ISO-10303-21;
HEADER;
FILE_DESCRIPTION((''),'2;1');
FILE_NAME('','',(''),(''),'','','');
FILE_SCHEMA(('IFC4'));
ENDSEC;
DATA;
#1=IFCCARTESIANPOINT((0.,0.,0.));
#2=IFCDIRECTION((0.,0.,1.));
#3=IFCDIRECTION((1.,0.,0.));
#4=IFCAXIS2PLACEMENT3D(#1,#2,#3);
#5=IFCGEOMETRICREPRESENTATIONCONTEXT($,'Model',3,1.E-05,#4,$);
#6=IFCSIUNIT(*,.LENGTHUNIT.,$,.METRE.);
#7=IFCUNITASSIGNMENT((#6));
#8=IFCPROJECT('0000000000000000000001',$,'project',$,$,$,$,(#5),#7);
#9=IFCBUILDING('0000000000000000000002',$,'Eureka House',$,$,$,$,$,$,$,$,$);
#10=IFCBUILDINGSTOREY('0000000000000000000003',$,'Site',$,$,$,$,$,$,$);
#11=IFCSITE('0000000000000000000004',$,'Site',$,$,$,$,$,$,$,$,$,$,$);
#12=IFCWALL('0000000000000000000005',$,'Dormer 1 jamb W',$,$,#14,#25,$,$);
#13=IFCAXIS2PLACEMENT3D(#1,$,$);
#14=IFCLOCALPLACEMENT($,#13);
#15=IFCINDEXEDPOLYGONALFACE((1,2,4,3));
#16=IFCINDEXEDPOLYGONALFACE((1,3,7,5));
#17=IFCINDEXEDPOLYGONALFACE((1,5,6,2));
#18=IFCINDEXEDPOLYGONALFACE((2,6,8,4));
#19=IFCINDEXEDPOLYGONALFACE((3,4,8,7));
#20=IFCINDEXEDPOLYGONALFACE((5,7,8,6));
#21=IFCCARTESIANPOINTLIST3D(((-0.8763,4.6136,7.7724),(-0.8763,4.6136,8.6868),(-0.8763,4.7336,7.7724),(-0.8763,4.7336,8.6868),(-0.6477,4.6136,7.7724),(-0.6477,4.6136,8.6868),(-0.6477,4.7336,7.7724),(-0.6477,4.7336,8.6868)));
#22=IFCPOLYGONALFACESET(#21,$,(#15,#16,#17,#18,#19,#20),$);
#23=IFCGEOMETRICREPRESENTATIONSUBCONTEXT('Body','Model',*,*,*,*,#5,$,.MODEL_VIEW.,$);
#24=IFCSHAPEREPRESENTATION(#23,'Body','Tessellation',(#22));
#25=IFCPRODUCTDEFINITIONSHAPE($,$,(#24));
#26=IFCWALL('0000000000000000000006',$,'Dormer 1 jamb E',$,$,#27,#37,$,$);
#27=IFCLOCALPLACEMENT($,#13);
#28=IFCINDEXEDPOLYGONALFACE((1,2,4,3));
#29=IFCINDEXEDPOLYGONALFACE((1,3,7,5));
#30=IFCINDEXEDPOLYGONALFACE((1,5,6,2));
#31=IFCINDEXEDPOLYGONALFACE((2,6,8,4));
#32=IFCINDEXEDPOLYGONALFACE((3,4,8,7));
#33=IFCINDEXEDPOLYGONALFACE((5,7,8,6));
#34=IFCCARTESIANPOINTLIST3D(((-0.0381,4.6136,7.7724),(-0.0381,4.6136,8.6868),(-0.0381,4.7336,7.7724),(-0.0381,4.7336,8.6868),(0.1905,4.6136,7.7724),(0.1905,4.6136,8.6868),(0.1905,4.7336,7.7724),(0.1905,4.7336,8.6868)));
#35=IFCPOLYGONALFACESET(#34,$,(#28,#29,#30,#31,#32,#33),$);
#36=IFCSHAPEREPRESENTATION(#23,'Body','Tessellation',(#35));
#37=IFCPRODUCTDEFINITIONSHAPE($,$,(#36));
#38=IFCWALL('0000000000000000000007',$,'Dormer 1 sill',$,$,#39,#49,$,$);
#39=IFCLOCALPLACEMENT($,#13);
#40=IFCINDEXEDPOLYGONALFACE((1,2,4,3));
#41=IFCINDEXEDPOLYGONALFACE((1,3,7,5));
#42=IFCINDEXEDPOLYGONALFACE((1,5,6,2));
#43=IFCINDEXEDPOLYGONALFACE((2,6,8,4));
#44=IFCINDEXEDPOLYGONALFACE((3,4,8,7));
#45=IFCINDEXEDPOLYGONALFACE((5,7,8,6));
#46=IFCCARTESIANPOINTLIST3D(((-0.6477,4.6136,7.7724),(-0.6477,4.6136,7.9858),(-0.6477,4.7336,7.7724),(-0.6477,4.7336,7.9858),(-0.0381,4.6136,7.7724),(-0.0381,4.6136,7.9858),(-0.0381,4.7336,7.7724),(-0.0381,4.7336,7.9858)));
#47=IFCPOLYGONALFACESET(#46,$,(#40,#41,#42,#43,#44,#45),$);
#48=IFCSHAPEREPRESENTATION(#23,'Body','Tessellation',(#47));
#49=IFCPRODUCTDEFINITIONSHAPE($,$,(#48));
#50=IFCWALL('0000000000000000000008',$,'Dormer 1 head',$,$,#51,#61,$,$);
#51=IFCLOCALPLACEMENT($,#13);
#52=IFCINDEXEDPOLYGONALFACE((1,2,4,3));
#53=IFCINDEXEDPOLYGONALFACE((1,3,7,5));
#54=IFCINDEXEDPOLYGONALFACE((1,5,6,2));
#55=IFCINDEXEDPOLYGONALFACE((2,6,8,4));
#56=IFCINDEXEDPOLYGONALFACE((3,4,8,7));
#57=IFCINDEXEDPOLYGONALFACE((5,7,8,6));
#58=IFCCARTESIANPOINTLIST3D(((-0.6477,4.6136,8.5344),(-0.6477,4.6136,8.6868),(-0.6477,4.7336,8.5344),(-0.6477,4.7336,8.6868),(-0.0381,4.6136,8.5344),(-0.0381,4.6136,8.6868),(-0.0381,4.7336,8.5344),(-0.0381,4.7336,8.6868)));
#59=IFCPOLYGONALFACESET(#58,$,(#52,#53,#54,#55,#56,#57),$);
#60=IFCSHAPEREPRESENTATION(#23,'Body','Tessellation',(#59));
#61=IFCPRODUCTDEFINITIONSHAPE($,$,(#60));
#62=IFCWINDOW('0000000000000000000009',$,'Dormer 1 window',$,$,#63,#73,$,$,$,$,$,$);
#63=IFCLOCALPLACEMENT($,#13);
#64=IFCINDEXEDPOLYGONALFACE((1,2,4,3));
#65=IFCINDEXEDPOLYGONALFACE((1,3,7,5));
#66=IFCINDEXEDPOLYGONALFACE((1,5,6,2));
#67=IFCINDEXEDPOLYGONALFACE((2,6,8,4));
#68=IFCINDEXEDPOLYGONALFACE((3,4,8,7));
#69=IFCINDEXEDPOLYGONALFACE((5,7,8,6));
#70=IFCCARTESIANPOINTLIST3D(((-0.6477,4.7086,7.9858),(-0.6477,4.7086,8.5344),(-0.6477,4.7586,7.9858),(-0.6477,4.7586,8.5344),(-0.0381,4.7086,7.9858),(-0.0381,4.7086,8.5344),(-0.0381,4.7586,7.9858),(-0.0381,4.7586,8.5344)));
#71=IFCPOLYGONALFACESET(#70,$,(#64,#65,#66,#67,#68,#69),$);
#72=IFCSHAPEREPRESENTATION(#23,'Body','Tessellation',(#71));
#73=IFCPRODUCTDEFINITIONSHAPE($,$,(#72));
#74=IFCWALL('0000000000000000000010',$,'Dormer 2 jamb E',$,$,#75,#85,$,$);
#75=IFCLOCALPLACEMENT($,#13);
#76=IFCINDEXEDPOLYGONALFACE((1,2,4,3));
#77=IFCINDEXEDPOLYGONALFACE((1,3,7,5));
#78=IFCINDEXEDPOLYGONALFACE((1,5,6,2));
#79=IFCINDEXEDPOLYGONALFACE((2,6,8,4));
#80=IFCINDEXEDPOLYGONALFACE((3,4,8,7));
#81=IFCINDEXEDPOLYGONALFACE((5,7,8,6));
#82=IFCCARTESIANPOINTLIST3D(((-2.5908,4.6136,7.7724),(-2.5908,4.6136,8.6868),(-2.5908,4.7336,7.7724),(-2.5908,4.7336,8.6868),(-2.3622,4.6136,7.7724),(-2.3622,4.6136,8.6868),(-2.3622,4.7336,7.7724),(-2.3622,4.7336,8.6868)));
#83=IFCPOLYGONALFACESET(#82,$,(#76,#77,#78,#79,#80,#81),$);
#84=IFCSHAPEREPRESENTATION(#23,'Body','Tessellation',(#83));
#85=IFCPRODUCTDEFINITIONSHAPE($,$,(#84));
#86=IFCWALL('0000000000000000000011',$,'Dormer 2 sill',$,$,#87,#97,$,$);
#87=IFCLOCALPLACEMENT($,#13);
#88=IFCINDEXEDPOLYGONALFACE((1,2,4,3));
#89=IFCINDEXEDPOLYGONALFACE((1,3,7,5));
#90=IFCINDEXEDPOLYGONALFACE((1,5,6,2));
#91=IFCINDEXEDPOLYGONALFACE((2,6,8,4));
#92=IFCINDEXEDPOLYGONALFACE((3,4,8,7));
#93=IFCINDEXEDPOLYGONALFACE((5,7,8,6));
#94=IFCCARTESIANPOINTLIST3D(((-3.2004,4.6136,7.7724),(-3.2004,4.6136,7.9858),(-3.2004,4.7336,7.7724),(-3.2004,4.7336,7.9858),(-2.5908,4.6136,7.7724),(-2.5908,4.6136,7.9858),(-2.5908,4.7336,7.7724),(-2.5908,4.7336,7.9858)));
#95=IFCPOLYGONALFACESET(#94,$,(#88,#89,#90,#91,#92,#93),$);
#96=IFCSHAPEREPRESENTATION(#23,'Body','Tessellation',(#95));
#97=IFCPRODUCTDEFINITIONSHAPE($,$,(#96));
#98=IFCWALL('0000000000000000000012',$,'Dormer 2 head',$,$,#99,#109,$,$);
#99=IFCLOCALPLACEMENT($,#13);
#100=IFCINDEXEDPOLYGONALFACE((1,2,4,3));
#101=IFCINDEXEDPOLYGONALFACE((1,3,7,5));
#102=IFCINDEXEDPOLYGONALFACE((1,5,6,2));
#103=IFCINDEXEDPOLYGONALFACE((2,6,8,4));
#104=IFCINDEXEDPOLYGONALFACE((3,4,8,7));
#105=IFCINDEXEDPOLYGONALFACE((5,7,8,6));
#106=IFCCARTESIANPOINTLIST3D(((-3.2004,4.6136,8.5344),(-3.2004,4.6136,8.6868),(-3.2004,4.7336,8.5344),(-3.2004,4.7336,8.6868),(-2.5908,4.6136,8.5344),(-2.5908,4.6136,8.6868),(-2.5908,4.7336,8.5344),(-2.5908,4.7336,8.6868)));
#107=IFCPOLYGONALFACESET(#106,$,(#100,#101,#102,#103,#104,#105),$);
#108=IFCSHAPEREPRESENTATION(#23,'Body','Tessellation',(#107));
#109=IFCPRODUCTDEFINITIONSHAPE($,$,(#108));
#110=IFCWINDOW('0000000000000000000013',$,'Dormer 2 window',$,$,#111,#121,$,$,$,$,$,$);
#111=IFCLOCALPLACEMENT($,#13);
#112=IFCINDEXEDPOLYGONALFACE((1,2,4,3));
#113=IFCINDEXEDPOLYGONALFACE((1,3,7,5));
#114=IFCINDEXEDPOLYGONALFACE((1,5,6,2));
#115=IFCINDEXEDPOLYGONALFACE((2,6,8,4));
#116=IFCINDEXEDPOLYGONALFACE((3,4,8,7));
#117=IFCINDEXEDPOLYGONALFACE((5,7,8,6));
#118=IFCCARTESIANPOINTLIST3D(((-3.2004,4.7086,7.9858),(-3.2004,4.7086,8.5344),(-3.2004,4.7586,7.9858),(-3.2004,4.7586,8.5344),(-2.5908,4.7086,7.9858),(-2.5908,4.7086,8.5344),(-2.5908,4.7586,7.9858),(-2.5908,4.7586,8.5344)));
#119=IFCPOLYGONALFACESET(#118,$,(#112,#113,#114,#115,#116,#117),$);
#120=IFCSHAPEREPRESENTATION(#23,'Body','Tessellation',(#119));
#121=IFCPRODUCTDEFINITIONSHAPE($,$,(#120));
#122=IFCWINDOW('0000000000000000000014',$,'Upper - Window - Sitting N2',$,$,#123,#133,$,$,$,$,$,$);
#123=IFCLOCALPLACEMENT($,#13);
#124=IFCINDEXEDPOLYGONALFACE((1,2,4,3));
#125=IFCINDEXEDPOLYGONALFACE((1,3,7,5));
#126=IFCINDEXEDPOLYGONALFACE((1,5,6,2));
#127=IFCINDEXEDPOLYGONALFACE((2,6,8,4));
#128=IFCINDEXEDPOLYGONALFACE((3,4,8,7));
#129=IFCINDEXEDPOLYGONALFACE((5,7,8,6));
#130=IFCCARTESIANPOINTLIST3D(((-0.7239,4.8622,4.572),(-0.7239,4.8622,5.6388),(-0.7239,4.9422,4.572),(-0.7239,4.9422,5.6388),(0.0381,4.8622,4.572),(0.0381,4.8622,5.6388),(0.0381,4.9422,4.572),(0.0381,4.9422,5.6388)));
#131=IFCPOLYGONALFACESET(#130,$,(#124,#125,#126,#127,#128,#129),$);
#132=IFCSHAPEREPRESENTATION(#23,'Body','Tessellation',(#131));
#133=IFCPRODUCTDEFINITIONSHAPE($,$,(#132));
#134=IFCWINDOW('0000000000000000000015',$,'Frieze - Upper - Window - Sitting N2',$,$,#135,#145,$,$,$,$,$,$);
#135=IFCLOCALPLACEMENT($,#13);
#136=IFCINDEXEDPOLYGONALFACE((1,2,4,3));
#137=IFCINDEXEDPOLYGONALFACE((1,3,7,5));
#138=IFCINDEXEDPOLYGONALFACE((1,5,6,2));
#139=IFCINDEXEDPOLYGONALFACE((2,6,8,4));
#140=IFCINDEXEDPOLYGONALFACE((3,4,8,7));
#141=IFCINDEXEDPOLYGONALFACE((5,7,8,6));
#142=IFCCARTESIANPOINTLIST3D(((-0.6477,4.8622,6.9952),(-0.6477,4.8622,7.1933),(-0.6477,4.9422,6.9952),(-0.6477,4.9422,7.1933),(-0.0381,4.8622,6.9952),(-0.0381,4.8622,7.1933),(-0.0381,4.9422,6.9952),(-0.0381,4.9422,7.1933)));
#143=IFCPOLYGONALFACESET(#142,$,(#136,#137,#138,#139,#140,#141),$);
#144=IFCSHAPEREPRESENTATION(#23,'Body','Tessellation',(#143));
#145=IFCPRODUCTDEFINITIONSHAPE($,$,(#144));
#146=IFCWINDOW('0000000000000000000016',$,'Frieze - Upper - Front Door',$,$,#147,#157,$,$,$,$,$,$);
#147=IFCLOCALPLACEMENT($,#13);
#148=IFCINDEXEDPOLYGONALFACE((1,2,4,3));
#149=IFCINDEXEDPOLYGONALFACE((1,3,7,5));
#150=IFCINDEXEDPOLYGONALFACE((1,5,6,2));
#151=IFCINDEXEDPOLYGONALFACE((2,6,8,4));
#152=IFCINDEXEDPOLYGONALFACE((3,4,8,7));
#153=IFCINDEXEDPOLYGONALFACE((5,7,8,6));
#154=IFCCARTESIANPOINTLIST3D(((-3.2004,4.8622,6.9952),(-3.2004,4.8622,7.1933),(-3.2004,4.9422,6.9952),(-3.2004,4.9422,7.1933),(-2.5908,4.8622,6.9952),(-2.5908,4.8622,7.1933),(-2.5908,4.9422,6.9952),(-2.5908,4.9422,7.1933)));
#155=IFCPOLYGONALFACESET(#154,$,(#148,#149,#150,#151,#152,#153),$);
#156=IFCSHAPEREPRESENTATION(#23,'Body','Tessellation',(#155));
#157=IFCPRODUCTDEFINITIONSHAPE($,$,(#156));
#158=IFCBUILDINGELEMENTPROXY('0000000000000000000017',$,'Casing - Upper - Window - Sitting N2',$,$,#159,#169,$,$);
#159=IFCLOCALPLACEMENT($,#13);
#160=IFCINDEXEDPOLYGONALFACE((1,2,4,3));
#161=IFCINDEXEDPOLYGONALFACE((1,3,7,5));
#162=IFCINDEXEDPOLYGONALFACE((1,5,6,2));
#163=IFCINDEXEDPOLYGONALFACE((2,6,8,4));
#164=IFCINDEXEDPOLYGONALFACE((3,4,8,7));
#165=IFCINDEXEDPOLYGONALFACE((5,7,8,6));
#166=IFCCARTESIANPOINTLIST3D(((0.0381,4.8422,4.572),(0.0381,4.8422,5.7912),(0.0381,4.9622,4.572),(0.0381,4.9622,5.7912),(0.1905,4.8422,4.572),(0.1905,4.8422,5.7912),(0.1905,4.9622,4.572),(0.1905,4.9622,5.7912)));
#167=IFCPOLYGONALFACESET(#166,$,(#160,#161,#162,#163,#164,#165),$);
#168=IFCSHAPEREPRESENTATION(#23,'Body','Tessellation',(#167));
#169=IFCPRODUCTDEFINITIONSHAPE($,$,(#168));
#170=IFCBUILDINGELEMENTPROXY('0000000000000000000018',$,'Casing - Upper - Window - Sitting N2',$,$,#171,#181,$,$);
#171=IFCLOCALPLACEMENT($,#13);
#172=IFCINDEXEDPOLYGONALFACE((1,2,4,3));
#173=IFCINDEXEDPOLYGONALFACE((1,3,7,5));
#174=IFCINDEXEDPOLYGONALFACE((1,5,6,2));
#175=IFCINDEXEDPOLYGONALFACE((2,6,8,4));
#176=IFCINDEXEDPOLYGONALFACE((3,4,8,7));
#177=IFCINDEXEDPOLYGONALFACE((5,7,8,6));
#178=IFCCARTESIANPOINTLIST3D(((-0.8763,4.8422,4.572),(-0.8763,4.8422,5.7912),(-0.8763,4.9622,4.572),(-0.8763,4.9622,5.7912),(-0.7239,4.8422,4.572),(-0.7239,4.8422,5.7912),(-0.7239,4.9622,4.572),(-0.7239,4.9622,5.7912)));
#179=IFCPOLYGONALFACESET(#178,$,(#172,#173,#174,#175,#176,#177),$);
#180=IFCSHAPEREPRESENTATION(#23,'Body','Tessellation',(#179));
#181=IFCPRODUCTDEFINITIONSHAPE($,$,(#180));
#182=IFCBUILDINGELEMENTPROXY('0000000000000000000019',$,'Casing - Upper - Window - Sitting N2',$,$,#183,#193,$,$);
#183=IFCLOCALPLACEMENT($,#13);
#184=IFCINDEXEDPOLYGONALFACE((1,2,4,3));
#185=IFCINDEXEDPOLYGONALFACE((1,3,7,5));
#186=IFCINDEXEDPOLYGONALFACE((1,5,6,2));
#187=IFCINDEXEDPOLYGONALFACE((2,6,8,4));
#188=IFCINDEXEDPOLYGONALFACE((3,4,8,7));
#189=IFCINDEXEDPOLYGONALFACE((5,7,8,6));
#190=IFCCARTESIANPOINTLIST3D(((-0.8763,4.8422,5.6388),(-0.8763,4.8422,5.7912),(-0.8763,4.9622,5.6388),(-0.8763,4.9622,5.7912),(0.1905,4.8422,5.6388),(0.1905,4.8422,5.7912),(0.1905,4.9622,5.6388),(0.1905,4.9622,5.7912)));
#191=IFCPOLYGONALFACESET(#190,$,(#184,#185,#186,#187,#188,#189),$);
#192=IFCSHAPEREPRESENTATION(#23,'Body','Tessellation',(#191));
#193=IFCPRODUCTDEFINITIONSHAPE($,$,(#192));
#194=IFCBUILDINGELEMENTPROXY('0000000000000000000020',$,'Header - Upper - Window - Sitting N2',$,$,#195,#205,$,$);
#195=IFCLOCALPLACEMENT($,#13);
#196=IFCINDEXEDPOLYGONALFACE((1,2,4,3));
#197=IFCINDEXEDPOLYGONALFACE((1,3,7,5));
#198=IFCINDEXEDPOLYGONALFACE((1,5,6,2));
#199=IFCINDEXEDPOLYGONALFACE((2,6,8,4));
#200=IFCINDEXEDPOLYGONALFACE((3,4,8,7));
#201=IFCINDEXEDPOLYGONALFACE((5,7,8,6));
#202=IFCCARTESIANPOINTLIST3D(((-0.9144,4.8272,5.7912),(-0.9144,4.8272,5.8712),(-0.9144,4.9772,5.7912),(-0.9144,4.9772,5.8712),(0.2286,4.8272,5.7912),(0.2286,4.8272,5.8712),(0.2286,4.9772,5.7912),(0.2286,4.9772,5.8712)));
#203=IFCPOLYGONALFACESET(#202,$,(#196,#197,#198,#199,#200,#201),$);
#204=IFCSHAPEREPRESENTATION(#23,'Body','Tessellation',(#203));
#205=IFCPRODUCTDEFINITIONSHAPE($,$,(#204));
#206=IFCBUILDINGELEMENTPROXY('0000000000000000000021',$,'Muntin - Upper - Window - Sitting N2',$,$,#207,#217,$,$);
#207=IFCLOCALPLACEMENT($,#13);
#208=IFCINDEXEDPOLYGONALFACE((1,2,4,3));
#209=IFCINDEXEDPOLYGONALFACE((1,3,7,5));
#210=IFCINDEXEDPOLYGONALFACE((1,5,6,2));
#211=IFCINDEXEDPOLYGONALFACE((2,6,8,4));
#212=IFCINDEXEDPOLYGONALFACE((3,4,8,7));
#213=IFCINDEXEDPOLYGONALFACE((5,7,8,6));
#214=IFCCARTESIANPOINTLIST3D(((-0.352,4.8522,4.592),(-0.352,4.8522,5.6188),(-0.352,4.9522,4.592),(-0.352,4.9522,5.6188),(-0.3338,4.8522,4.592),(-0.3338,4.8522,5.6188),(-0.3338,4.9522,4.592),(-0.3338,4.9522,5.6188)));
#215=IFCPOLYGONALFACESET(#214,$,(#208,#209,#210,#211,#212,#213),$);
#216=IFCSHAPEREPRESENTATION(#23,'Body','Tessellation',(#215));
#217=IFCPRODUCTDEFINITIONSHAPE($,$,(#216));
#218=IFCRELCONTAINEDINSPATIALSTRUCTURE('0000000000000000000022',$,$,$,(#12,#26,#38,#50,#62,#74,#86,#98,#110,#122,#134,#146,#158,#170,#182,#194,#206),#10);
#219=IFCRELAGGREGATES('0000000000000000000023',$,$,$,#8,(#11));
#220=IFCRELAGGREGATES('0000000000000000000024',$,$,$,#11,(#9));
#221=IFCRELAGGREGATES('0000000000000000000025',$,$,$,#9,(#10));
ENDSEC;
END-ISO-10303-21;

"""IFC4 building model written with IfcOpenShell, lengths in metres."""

from ifc_helpers import new_model, si_unit, frame, origin, origin_with_axes, origin_2d, place, context, subcontext, project, spatial, rectangle, extrude, element, save


model = new_model("IFC4")

# Units and contexts
model_context = context("Model", 3, precision=1e-05, world=origin_with_axes())
body_context = subcontext(model_context, "Body", "Model", "MODEL_VIEW")
ifc_project = project(units=[si_unit("LENGTHUNIT", "METRE")], contexts=[model_context])

# Site, building, storey
site = spatial("IfcSite", under=ifc_project, Name="Site")
building = spatial("IfcBuilding", under=site, Name="Eureka House")
storey = spatial("IfcBuildingStorey", under=building, Name="Site")

# Walls
wall_1_placement = place(None, frame((-0.762, 4.6736, 7.7724), z_axis=(0.0, 0.0, 1.0), x_axis=(1.0, 0.0, 0.0)))
element("IfcWall", 1, at=wall_1_placement, inside=storey, Name="Dormer 1 jamb W", context=body_context, shape_type="SweptSolid", body=[
    extrude(rectangle(XDim=0.2286, YDim=0.12, at=origin_2d()), origin(), (0.0, 0.0, 1.0), 0.9144),
])
wall_2_placement = place(None, frame((0.0762, 4.6736, 7.7724), z_axis=(0.0, 0.0, 1.0), x_axis=(1.0, 0.0, 0.0)))
element("IfcWall", 2, at=wall_2_placement, inside=storey, Name="Dormer 1 jamb E", context=body_context, shape_type="SweptSolid", body=[
    extrude(rectangle(XDim=0.2286, YDim=0.12, at=origin_2d()), origin(), (0.0, 0.0, 1.0), 0.9144),
])
wall_3_placement = place(None, frame((-0.3429, 4.6736, 7.7724), z_axis=(0.0, 0.0, 1.0), x_axis=(1.0, 0.0, 0.0)))
element("IfcWall", 3, at=wall_3_placement, inside=storey, Name="Dormer 1 sill", context=body_context, shape_type="SweptSolid", body=[
    extrude(rectangle(XDim=0.6096, YDim=0.12, at=origin_2d()), origin(), (0.0, 0.0, 1.0), 0.2134),
])
wall_4_placement = place(None, frame((-0.3429, 4.6736, 8.5344), z_axis=(0.0, 0.0, 1.0), x_axis=(1.0, 0.0, 0.0)))
element("IfcWall", 4, at=wall_4_placement, inside=storey, Name="Dormer 1 head", context=body_context, shape_type="SweptSolid", body=[
    extrude(rectangle(XDim=0.6096, YDim=0.12, at=origin_2d()), origin(), (0.0, 0.0, 1.0), 0.1524),
])

# Window
window_1_placement = place(None, frame((-0.3429, 4.7336, 7.9858), z_axis=(0.0, 0.0, 1.0), x_axis=(1.0, 0.0, 0.0)))
element("IfcWindow", 5, at=window_1_placement, inside=storey, Name="Dormer 1 window", context=body_context, shape_type="SweptSolid", body=[
    extrude(rectangle(XDim=0.6096, YDim=0.05, at=origin_2d()), origin(), (0.0, 0.0, 1.0), 0.5486),
])

# Walls
wall_5_placement = place(None, frame((-2.4765, 4.6736, 7.7724), z_axis=(0.0, 0.0, 1.0), x_axis=(1.0, 0.0, 0.0)))
element("IfcWall", 6, at=wall_5_placement, inside=storey, Name="Dormer 2 jamb E", context=body_context, shape_type="SweptSolid", body=[
    extrude(rectangle(XDim=0.2286, YDim=0.12, at=origin_2d()), origin(), (0.0, 0.0, 1.0), 0.9144),
])
wall_6_placement = place(None, frame((-2.8956, 4.6736, 7.7724), z_axis=(0.0, 0.0, 1.0), x_axis=(1.0, 0.0, 0.0)))
element("IfcWall", 7, at=wall_6_placement, inside=storey, Name="Dormer 2 sill", context=body_context, shape_type="SweptSolid", body=[
    extrude(rectangle(XDim=0.6096, YDim=0.12, at=origin_2d()), origin(), (0.0, 0.0, 1.0), 0.2134),
])
wall_7_placement = place(None, frame((-2.8956, 4.6736, 8.5344), z_axis=(0.0, 0.0, 1.0), x_axis=(1.0, 0.0, 0.0)))
element("IfcWall", 8, at=wall_7_placement, inside=storey, Name="Dormer 2 head", context=body_context, shape_type="SweptSolid", body=[
    extrude(rectangle(XDim=0.6096, YDim=0.12, at=origin_2d()), origin(), (0.0, 0.0, 1.0), 0.1524),
])

# Windows
window_2_placement = place(None, frame((-2.8956, 4.7336, 7.9858), z_axis=(0.0, 0.0, 1.0), x_axis=(1.0, 0.0, 0.0)))
element("IfcWindow", 9, at=window_2_placement, inside=storey, Name="Dormer 2 window", context=body_context, shape_type="SweptSolid", body=[
    extrude(rectangle(XDim=0.6096, YDim=0.05, at=origin_2d()), origin(), (0.0, 0.0, 1.0), 0.5486),
])
window_3_placement = place(None, frame((-0.3429, 4.9022, 4.572), z_axis=(0.0, 0.0, 1.0), x_axis=(1.0, 0.0, 0.0)))
element("IfcWindow", 10, at=window_3_placement, inside=storey, Name="Upper - Window - Sitting N2", context=body_context, shape_type="SweptSolid", body=[
    extrude(rectangle(XDim=0.762, YDim=0.08, at=origin_2d()), origin(), (0.0, 0.0, 1.0), 1.0668),
])
for number, where, z_axis, x_axis, name in (
    (11, (-0.3429, 4.9022, 6.9952), (0.0, 0.0, 1.0), (1.0, 0.0, 0.0), "Frieze - Upper - Window - Sitting N2"),
    (12, (-2.8956, 4.9022, 6.9952), (0.0, 0.0, 1.0), (1.0, 0.0, 0.0), "Frieze - Upper - Front Door"),
):
    element("IfcWindow", number, at=place(None, frame(where, z_axis=z_axis, x_axis=x_axis)), inside=storey, Name=name, context=body_context, shape_type="SweptSolid", body=[
        extrude(rectangle(XDim=0.6096, YDim=0.08, at=origin_2d()), origin(), (0.0, 0.0, 1.0), 0.1981),
    ])

# Building element proxies
for number, where, z_axis, x_axis, name in (
    (13, (0.1143, 4.9022, 4.572), (0.0, 0.0, 1.0), (1.0, 0.0, 0.0), "Casing - Upper - Window - Sitting N2"),
    (14, (-0.8001, 4.9022, 4.572), (0.0, 0.0, 1.0), (1.0, 0.0, 0.0), "Casing - Upper - Window - Sitting N2"),
):
    element("IfcBuildingElementProxy", number, at=place(None, frame(where, z_axis=z_axis, x_axis=x_axis)), inside=storey, Name=name, context=body_context, shape_type="SweptSolid", body=[
        extrude(rectangle(XDim=0.1524, YDim=0.12, at=origin_2d()), origin(), (0.0, 0.0, 1.0), 1.2192),
    ])
proxy_1_placement = place(None, frame((-0.3429, 4.9022, 5.6388), z_axis=(0.0, 0.0, 1.0), x_axis=(1.0, 0.0, 0.0)))
element("IfcBuildingElementProxy", 15, at=proxy_1_placement, inside=storey, Name="Casing - Upper - Window - Sitting N2", context=body_context, shape_type="SweptSolid", body=[
    extrude(rectangle(XDim=1.0668, YDim=0.12, at=origin_2d()), origin(), (0.0, 0.0, 1.0), 0.1524),
])
proxy_2_placement = place(None, frame((-0.3429, 4.9022, 5.7912), z_axis=(0.0, 0.0, 1.0), x_axis=(1.0, 0.0, 0.0)))
element("IfcBuildingElementProxy", 16, at=proxy_2_placement, inside=storey, Name="Header - Upper - Window - Sitting N2", context=body_context, shape_type="SweptSolid", body=[
    extrude(rectangle(XDim=1.143, YDim=0.15, at=origin_2d()), origin(), (0.0, 0.0, 1.0), 0.08),
])
proxy_3_placement = place(None, frame((-0.3429, 4.9022, 4.592), z_axis=(0.0, 0.0, 1.0), x_axis=(1.0, 0.0, 0.0)))
element("IfcBuildingElementProxy", 17, at=proxy_3_placement, inside=storey, Name="Muntin - Upper - Window - Sitting N2", context=body_context, shape_type="SweptSolid", body=[
    extrude(rectangle(XDim=0.0183, YDim=0.1, at=origin_2d()), origin(), (0.0, 0.0, 1.0), 1.0268),
])

save(model, "model.ifc")
